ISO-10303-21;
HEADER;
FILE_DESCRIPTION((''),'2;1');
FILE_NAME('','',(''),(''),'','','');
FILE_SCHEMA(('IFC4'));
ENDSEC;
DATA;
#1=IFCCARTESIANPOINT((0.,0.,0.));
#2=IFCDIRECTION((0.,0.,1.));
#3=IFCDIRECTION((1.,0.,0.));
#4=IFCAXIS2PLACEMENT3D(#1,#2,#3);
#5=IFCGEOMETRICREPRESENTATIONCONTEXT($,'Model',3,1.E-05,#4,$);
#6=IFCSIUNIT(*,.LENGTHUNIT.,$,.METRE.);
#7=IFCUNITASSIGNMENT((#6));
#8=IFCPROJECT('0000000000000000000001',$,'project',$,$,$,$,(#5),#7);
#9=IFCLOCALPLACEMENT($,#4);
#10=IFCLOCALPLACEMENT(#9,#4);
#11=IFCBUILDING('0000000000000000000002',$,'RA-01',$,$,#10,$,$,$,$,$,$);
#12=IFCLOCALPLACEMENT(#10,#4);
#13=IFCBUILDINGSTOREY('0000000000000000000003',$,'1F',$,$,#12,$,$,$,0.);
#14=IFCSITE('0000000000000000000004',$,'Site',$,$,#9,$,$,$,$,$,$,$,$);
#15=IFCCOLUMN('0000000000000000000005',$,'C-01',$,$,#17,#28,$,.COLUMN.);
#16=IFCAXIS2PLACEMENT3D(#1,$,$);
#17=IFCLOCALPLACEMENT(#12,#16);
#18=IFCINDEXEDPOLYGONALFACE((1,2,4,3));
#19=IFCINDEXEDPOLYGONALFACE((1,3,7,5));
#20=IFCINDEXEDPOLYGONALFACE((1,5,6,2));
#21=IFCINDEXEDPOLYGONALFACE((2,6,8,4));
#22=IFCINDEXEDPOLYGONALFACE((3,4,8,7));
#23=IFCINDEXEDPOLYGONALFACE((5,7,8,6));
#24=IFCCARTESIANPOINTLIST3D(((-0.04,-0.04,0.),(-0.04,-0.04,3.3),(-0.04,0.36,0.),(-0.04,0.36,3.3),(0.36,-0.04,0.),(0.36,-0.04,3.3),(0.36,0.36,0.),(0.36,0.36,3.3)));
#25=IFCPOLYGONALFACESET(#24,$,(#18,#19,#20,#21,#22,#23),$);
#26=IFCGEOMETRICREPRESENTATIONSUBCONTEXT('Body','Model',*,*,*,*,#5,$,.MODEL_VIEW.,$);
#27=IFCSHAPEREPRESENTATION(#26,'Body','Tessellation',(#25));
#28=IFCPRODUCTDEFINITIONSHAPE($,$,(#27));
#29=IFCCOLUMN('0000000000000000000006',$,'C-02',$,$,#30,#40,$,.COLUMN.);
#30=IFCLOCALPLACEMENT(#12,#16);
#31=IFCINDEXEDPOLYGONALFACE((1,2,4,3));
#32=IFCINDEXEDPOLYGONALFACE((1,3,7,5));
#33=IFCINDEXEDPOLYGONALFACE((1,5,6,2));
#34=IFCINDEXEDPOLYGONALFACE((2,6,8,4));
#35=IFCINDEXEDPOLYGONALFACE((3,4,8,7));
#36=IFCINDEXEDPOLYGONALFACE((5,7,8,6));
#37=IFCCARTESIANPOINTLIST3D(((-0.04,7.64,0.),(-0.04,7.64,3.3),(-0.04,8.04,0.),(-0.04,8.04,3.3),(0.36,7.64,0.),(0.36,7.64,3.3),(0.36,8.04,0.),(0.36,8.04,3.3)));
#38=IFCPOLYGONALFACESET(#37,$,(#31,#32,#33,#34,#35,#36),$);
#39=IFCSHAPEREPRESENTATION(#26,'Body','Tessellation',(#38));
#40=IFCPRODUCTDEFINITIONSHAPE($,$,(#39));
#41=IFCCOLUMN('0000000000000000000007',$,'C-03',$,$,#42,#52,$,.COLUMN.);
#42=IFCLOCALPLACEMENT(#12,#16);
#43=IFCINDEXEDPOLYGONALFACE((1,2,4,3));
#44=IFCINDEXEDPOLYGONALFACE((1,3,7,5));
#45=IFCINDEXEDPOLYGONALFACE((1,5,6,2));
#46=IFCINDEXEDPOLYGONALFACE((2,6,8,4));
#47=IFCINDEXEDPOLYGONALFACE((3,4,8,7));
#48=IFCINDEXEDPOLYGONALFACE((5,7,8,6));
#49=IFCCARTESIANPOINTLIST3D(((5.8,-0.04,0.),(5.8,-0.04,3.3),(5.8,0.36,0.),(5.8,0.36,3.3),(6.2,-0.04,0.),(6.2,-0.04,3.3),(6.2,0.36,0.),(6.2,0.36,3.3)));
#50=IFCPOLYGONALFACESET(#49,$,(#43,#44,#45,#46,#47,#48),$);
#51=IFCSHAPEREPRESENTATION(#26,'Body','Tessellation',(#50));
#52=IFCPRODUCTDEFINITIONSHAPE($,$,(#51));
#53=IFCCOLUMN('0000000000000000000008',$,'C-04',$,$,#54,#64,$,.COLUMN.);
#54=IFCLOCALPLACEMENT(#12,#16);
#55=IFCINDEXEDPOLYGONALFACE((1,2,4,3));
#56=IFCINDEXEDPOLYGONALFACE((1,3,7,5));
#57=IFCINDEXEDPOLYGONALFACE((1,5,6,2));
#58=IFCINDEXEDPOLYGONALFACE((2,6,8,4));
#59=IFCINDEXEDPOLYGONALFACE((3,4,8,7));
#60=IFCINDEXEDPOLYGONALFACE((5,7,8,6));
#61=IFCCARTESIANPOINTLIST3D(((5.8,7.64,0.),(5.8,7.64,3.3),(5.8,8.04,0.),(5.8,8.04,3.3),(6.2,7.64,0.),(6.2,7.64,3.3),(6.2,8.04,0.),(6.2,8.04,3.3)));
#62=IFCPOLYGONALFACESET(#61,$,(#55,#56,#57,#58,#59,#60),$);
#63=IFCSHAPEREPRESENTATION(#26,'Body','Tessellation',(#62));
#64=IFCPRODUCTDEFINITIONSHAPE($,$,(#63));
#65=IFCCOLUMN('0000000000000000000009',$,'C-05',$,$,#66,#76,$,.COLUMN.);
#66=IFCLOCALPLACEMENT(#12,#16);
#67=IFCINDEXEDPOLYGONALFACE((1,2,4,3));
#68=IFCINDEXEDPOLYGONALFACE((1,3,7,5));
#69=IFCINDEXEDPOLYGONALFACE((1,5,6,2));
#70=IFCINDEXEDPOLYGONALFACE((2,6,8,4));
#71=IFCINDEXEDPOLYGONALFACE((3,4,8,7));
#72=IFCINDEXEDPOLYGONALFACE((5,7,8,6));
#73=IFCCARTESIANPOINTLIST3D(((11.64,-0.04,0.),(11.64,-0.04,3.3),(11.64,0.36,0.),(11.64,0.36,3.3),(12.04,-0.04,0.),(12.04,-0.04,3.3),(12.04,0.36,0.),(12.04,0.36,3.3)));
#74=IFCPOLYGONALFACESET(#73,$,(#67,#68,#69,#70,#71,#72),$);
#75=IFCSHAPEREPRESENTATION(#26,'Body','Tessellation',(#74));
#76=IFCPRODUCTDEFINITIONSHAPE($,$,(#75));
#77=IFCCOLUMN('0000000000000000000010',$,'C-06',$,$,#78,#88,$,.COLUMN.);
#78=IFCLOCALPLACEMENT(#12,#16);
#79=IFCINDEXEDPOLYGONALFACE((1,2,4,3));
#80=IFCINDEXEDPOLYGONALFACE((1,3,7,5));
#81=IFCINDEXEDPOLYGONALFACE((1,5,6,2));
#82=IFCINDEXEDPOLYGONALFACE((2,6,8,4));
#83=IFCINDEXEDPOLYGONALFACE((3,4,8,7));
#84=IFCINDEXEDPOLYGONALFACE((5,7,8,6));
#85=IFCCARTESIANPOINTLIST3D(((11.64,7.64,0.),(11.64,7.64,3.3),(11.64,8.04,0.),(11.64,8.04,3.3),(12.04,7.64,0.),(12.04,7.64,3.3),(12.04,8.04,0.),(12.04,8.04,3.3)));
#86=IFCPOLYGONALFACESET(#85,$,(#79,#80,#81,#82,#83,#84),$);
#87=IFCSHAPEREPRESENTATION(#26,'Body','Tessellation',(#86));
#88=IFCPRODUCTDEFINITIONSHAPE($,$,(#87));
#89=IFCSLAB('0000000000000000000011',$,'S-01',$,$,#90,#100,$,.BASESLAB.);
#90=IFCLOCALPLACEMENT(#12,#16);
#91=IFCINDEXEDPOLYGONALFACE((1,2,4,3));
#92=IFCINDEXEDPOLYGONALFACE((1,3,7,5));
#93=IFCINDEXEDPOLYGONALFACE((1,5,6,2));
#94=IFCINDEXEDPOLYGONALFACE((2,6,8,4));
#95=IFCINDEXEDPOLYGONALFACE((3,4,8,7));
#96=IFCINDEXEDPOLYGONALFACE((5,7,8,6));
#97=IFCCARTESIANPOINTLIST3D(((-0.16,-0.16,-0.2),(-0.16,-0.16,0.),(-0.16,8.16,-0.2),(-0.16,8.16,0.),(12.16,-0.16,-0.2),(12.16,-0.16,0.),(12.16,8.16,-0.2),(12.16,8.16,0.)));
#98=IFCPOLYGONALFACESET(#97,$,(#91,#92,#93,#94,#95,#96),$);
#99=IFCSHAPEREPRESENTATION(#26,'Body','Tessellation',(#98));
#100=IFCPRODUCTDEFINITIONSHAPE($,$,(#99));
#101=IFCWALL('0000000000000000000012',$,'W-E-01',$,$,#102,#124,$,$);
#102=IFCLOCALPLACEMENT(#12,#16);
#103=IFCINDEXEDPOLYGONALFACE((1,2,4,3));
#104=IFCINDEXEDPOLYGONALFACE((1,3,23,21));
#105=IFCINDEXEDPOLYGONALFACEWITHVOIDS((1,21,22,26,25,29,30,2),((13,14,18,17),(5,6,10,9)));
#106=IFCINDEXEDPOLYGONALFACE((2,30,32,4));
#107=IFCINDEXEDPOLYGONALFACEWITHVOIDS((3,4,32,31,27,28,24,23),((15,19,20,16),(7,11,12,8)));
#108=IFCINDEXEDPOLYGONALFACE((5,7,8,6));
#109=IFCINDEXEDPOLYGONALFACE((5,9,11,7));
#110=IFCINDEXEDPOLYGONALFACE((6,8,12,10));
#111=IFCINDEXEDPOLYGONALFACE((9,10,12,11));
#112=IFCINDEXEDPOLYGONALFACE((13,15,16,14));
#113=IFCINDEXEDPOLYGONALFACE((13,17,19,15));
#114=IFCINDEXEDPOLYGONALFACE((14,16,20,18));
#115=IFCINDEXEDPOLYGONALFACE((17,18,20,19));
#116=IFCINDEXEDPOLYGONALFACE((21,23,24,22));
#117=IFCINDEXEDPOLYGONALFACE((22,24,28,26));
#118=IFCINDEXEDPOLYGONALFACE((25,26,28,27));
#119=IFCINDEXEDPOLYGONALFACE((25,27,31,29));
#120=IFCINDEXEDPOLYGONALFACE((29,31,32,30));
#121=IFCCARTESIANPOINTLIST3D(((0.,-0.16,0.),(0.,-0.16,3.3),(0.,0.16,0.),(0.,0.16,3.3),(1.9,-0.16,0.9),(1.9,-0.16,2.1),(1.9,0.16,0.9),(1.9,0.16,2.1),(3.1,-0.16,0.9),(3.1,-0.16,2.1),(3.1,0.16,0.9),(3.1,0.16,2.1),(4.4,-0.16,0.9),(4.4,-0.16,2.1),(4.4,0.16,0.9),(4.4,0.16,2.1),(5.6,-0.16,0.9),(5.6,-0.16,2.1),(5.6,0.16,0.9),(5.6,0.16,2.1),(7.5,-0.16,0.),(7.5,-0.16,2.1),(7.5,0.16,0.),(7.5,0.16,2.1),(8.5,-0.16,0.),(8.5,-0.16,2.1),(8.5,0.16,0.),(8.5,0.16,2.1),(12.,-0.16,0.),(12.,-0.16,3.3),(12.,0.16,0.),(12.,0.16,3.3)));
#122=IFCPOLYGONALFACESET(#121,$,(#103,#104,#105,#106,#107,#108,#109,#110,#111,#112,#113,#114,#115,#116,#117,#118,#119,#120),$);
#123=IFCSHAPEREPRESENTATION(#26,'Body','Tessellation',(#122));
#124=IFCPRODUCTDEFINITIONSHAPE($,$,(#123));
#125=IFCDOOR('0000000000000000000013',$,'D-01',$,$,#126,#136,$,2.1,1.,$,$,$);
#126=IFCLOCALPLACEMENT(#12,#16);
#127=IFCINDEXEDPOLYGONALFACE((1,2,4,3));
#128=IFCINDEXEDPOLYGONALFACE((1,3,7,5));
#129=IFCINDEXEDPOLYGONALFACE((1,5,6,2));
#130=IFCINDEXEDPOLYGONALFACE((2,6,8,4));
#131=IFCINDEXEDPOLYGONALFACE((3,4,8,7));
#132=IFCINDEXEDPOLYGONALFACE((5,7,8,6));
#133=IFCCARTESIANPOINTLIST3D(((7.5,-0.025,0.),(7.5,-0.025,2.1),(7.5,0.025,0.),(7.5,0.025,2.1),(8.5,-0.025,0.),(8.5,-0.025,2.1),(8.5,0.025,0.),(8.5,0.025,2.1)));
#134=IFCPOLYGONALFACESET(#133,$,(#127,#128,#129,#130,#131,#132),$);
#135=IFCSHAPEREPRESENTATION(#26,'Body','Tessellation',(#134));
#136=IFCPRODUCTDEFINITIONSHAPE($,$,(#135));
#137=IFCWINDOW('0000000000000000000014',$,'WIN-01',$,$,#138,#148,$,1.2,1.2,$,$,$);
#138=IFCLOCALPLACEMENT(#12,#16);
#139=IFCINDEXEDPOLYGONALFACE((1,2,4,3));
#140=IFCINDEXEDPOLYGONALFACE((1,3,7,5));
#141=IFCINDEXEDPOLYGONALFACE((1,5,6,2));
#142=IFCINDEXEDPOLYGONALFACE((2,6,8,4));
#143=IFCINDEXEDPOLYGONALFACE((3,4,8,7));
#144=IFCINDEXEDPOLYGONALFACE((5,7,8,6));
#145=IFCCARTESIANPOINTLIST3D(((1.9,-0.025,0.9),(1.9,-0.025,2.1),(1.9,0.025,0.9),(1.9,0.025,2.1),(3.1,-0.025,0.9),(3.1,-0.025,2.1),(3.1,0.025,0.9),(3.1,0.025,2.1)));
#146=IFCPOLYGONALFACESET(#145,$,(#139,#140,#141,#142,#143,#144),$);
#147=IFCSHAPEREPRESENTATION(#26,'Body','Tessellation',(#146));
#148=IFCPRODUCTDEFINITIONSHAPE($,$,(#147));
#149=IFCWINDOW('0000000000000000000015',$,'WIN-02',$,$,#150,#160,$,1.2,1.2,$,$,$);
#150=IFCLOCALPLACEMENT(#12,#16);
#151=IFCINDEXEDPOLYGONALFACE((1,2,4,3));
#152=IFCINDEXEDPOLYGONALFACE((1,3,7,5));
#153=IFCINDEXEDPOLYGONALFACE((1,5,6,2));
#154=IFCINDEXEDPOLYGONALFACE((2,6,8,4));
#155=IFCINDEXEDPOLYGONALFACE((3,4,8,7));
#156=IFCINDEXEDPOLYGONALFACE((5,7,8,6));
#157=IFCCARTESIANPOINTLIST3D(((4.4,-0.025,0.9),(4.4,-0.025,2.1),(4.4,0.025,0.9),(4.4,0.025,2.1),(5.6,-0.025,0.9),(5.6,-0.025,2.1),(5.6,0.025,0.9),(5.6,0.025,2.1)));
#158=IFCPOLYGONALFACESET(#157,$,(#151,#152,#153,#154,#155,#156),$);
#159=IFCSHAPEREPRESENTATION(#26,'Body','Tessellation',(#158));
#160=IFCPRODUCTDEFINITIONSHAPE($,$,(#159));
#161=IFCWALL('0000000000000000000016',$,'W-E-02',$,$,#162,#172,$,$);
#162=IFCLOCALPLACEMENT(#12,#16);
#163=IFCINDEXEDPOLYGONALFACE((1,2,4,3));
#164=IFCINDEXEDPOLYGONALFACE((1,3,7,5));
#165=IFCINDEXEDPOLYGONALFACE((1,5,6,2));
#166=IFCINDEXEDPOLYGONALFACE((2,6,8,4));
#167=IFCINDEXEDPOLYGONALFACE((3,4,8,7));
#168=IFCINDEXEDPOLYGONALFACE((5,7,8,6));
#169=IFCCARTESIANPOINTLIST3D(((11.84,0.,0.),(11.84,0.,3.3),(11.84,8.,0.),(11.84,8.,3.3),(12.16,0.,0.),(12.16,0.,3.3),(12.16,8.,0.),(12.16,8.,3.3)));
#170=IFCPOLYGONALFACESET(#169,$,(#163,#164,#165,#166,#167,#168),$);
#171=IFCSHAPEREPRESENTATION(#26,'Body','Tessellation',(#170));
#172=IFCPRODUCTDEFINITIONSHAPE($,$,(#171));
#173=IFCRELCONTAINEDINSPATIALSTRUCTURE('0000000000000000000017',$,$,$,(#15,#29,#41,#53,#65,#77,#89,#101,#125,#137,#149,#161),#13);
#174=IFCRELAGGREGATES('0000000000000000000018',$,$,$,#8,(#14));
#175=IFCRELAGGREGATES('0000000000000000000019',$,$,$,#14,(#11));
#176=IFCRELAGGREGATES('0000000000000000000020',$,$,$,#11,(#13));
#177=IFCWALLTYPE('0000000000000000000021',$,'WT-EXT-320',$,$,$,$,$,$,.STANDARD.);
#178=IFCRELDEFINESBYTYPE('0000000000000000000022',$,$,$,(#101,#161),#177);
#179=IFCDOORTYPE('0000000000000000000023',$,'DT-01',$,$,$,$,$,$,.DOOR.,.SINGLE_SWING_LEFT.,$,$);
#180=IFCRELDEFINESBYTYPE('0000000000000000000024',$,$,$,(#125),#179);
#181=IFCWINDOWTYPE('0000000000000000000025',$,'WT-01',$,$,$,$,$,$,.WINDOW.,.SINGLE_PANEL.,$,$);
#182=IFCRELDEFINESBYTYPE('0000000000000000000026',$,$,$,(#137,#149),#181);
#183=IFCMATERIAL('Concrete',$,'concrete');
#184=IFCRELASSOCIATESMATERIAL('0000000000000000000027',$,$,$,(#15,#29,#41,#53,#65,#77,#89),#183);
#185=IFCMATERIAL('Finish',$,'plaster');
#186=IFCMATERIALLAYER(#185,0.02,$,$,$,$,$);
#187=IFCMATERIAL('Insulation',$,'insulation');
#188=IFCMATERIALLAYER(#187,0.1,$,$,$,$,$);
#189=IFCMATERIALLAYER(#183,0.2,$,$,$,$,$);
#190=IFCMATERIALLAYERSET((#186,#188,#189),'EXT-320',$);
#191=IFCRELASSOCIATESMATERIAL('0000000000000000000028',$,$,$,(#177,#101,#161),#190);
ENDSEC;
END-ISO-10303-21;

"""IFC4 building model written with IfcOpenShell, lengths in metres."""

from ifc_helpers import new_model, si_unit, frame, frame_2d, origin_with_axes, origin_2d_with_axis, place, context, subcontext, project, spatial, polyline, rectangle, outline, extrude, material, layer, layer_set, layer_usage, type_object, element, fill, save


model = new_model("IFC4")

# Units and contexts
model_context = context("Model", 3, precision=1e-05, world=origin_with_axes())
body_context = subcontext(model_context, "Body", "Model", "MODEL_VIEW")
ifc_project = project(units=[si_unit("LENGTHUNIT", "METRE")], contexts=[model_context])

# Site, building, storey
site_placement = place(None, origin_with_axes())
site = spatial("IfcSite", under=ifc_project, at=site_placement, Name="Site")
building_placement = place(site_placement, origin_with_axes())
building = spatial("IfcBuilding", under=site, at=building_placement, Name="RA-01")
storey_placement = place(building_placement, origin_with_axes())
storey = spatial("IfcBuildingStorey", under=building, at=storey_placement, Name="1F", Elevation=0.0)

# Columns
ifc_material_1 = material(Name="Concrete", Category="concrete")
for number, where, z_axis, x_axis, name in (
    (1, (0.16, 0.16, 0.0), (0.0, 0.0, 1.0), (1.0, 0.0, 0.0), "C-01"),
    (2, (0.16, 7.84, 0.0), (0.0, 0.0, 1.0), (1.0, 0.0, 0.0), "C-02"),
    (3, (6.0, 0.16, 0.0), (0.0, 0.0, 1.0), (1.0, 0.0, 0.0), "C-03"),
    (4, (6.0, 7.84, 0.0), (0.0, 0.0, 1.0), (1.0, 0.0, 0.0), "C-04"),
    (5, (11.84, 0.16, 0.0), (0.0, 0.0, 1.0), (1.0, 0.0, 0.0), "C-05"),
    (6, (11.84, 7.84, 0.0), (0.0, 0.0, 1.0), (1.0, 0.0, 0.0), "C-06"),
):
    element("IfcColumn", number, at=place(storey_placement, frame(where, z_axis=z_axis, x_axis=x_axis)), inside=storey, material=ifc_material_1, Name=name, PredefinedType="COLUMN", context=body_context, shape_type="SweptSolid", body=[
        extrude(rectangle(XDim=0.4, YDim=0.4, at=origin_2d_with_axis()), origin_with_axes(), (0.0, 0.0, 1.0), 3.3),
    ])

# Slab
slab_placement = place(storey_placement, frame((0.0, 0.0, -0.2), z_axis=(0.0, 0.0, 1.0), x_axis=(1.0, 0.0, 0.0)))
element("IfcSlab", 7, at=slab_placement, inside=storey, material=ifc_material_1, Name="S-01", PredefinedType="BASESLAB", context=body_context, shape_type="SweptSolid", body=[
    extrude(outline(polyline([(-0.16, -0.16), (12.16, -0.16), (12.16, 8.16), (-0.16, 8.16), (-0.16, -0.16)])), origin_with_axes(), (0.0, 0.0, 1.0), 0.2),
])

# Wall, openings, door, windows
ifc_material_2 = material(Name="Finish", Category="plaster")
ifc_layer_1 = layer(ifc_material_2, 0.02)
ifc_material_3 = material(Name="Insulation", Category="insulation")
ifc_layer_2 = layer(ifc_material_3, 0.1)
ifc_layer_3 = layer(ifc_material_1, 0.2)
ifc_layer_set_1 = layer_set([ifc_layer_1, ifc_layer_2, ifc_layer_3], Name="EXT-320")
ifc_layer_usage_1 = layer_usage(ifc_layer_set_1, "AXIS2", "POSITIVE", -0.16)
wall_type_1 = type_object("IfcWallType", Name="WT-EXT-320", PredefinedType="STANDARD", material=ifc_layer_set_1)
wall_1_placement = place(storey_placement, origin_with_axes())
wall_1 = element("IfcWall", 8, at=wall_1_placement, inside=storey, type_object=wall_type_1, material=ifc_layer_usage_1, Name="W-E-01", context=body_context, shape_type="SweptSolid", body=[
    extrude(rectangle(XDim=12.0, YDim=0.32, at=frame_2d((6.0, 0.0), x_axis=(1.0, 0.0))), origin_with_axes(), (0.0, 0.0, 1.0), 3.3),
])
opening_1_placement = place(wall_1_placement, frame((8.0, 0.0, 0.0), z_axis=(0.0, 0.0, 1.0), x_axis=(1.0, 0.0, 0.0)))
opening_1 = element("IfcOpeningElement", 9, at=opening_1_placement, cuts=wall_1, PredefinedType="OPENING", context=body_context, shape_type="SweptSolid", body=[
    extrude(rectangle(XDim=1.0, YDim=0.42, at=origin_2d_with_axis()), origin_with_axes(), (0.0, 0.0, 1.0), 2.1),
])
opening_2_placement = place(wall_1_placement, frame((2.5, 0.0, 0.9), z_axis=(0.0, 0.0, 1.0), x_axis=(1.0, 0.0, 0.0)))
opening_2 = element("IfcOpeningElement", 10, at=opening_2_placement, cuts=wall_1, PredefinedType="OPENING", context=body_context, shape_type="SweptSolid", body=[
    extrude(rectangle(XDim=1.2, YDim=0.42, at=origin_2d_with_axis()), origin_with_axes(), (0.0, 0.0, 1.0), 1.2),
])
opening_3_placement = place(wall_1_placement, frame((5.0, 0.0, 0.9), z_axis=(0.0, 0.0, 1.0), x_axis=(1.0, 0.0, 0.0)))
opening_3 = element("IfcOpeningElement", 11, at=opening_3_placement, cuts=wall_1, PredefinedType="OPENING", context=body_context, shape_type="SweptSolid", body=[
    extrude(rectangle(XDim=1.2, YDim=0.42, at=origin_2d_with_axis()), origin_with_axes(), (0.0, 0.0, 1.0), 1.2),
])
door_type_1 = type_object("IfcDoorType", Name="DT-01", OperationType="SINGLE_SWING_LEFT", PredefinedType="DOOR")
door_1_placement = place(opening_1_placement, origin_with_axes())
door_1 = element("IfcDoor", 12, at=door_1_placement, inside=storey, type_object=door_type_1, Name="D-01", OverallHeight=2.1, OverallWidth=1.0, context=body_context, shape_type="SweptSolid", body=[
    extrude(rectangle(XDim=1.0, YDim=0.05, at=origin_2d_with_axis()), origin_with_axes(), (0.0, 0.0, 1.0), 2.1),
])
fill(opening_1, door_1)
window_type_1 = type_object("IfcWindowType", Name="WT-01", PartitioningType="SINGLE_PANEL", PredefinedType="WINDOW")
window_1_placement = place(opening_2_placement, origin_with_axes())
window_1 = element("IfcWindow", 13, at=window_1_placement, inside=storey, type_object=window_type_1, Name="WIN-01", OverallHeight=1.2, OverallWidth=1.2, context=body_context, shape_type="SweptSolid", body=[
    extrude(rectangle(XDim=1.2, YDim=0.05, at=origin_2d_with_axis()), origin_with_axes(), (0.0, 0.0, 1.0), 1.2),
])
fill(opening_2, window_1)
window_2_placement = place(opening_3_placement, origin_with_axes())
window_2 = element("IfcWindow", 14, at=window_2_placement, inside=storey, type_object=window_type_1, Name="WIN-02", OverallHeight=1.2, OverallWidth=1.2, context=body_context, shape_type="SweptSolid", body=[
    extrude(rectangle(XDim=1.2, YDim=0.05, at=origin_2d_with_axis()), origin_with_axes(), (0.0, 0.0, 1.0), 1.2),
])
fill(opening_3, window_2)

# Wall
ifc_layer_usage_2 = layer_usage(ifc_layer_set_1, "AXIS2", "POSITIVE", -0.16)
wall_2_placement = place(storey_placement, frame((12.0, 0.0, 0.0), z_axis=(0.0, 0.0, 1.0), x_axis=(0.0, 1.0, 0.0)))
element("IfcWall", 15, at=wall_2_placement, inside=storey, type_object=wall_type_1, material=ifc_layer_usage_2, Name="W-E-02", context=body_context, shape_type="SweptSolid", body=[
    extrude(rectangle(XDim=8.0, YDim=0.32, at=frame_2d((4.0, 0.0), x_axis=(1.0, 0.0))), origin_with_axes(), (0.0, 0.0, 1.0), 3.3),
])

save(model, "model.ifc")
